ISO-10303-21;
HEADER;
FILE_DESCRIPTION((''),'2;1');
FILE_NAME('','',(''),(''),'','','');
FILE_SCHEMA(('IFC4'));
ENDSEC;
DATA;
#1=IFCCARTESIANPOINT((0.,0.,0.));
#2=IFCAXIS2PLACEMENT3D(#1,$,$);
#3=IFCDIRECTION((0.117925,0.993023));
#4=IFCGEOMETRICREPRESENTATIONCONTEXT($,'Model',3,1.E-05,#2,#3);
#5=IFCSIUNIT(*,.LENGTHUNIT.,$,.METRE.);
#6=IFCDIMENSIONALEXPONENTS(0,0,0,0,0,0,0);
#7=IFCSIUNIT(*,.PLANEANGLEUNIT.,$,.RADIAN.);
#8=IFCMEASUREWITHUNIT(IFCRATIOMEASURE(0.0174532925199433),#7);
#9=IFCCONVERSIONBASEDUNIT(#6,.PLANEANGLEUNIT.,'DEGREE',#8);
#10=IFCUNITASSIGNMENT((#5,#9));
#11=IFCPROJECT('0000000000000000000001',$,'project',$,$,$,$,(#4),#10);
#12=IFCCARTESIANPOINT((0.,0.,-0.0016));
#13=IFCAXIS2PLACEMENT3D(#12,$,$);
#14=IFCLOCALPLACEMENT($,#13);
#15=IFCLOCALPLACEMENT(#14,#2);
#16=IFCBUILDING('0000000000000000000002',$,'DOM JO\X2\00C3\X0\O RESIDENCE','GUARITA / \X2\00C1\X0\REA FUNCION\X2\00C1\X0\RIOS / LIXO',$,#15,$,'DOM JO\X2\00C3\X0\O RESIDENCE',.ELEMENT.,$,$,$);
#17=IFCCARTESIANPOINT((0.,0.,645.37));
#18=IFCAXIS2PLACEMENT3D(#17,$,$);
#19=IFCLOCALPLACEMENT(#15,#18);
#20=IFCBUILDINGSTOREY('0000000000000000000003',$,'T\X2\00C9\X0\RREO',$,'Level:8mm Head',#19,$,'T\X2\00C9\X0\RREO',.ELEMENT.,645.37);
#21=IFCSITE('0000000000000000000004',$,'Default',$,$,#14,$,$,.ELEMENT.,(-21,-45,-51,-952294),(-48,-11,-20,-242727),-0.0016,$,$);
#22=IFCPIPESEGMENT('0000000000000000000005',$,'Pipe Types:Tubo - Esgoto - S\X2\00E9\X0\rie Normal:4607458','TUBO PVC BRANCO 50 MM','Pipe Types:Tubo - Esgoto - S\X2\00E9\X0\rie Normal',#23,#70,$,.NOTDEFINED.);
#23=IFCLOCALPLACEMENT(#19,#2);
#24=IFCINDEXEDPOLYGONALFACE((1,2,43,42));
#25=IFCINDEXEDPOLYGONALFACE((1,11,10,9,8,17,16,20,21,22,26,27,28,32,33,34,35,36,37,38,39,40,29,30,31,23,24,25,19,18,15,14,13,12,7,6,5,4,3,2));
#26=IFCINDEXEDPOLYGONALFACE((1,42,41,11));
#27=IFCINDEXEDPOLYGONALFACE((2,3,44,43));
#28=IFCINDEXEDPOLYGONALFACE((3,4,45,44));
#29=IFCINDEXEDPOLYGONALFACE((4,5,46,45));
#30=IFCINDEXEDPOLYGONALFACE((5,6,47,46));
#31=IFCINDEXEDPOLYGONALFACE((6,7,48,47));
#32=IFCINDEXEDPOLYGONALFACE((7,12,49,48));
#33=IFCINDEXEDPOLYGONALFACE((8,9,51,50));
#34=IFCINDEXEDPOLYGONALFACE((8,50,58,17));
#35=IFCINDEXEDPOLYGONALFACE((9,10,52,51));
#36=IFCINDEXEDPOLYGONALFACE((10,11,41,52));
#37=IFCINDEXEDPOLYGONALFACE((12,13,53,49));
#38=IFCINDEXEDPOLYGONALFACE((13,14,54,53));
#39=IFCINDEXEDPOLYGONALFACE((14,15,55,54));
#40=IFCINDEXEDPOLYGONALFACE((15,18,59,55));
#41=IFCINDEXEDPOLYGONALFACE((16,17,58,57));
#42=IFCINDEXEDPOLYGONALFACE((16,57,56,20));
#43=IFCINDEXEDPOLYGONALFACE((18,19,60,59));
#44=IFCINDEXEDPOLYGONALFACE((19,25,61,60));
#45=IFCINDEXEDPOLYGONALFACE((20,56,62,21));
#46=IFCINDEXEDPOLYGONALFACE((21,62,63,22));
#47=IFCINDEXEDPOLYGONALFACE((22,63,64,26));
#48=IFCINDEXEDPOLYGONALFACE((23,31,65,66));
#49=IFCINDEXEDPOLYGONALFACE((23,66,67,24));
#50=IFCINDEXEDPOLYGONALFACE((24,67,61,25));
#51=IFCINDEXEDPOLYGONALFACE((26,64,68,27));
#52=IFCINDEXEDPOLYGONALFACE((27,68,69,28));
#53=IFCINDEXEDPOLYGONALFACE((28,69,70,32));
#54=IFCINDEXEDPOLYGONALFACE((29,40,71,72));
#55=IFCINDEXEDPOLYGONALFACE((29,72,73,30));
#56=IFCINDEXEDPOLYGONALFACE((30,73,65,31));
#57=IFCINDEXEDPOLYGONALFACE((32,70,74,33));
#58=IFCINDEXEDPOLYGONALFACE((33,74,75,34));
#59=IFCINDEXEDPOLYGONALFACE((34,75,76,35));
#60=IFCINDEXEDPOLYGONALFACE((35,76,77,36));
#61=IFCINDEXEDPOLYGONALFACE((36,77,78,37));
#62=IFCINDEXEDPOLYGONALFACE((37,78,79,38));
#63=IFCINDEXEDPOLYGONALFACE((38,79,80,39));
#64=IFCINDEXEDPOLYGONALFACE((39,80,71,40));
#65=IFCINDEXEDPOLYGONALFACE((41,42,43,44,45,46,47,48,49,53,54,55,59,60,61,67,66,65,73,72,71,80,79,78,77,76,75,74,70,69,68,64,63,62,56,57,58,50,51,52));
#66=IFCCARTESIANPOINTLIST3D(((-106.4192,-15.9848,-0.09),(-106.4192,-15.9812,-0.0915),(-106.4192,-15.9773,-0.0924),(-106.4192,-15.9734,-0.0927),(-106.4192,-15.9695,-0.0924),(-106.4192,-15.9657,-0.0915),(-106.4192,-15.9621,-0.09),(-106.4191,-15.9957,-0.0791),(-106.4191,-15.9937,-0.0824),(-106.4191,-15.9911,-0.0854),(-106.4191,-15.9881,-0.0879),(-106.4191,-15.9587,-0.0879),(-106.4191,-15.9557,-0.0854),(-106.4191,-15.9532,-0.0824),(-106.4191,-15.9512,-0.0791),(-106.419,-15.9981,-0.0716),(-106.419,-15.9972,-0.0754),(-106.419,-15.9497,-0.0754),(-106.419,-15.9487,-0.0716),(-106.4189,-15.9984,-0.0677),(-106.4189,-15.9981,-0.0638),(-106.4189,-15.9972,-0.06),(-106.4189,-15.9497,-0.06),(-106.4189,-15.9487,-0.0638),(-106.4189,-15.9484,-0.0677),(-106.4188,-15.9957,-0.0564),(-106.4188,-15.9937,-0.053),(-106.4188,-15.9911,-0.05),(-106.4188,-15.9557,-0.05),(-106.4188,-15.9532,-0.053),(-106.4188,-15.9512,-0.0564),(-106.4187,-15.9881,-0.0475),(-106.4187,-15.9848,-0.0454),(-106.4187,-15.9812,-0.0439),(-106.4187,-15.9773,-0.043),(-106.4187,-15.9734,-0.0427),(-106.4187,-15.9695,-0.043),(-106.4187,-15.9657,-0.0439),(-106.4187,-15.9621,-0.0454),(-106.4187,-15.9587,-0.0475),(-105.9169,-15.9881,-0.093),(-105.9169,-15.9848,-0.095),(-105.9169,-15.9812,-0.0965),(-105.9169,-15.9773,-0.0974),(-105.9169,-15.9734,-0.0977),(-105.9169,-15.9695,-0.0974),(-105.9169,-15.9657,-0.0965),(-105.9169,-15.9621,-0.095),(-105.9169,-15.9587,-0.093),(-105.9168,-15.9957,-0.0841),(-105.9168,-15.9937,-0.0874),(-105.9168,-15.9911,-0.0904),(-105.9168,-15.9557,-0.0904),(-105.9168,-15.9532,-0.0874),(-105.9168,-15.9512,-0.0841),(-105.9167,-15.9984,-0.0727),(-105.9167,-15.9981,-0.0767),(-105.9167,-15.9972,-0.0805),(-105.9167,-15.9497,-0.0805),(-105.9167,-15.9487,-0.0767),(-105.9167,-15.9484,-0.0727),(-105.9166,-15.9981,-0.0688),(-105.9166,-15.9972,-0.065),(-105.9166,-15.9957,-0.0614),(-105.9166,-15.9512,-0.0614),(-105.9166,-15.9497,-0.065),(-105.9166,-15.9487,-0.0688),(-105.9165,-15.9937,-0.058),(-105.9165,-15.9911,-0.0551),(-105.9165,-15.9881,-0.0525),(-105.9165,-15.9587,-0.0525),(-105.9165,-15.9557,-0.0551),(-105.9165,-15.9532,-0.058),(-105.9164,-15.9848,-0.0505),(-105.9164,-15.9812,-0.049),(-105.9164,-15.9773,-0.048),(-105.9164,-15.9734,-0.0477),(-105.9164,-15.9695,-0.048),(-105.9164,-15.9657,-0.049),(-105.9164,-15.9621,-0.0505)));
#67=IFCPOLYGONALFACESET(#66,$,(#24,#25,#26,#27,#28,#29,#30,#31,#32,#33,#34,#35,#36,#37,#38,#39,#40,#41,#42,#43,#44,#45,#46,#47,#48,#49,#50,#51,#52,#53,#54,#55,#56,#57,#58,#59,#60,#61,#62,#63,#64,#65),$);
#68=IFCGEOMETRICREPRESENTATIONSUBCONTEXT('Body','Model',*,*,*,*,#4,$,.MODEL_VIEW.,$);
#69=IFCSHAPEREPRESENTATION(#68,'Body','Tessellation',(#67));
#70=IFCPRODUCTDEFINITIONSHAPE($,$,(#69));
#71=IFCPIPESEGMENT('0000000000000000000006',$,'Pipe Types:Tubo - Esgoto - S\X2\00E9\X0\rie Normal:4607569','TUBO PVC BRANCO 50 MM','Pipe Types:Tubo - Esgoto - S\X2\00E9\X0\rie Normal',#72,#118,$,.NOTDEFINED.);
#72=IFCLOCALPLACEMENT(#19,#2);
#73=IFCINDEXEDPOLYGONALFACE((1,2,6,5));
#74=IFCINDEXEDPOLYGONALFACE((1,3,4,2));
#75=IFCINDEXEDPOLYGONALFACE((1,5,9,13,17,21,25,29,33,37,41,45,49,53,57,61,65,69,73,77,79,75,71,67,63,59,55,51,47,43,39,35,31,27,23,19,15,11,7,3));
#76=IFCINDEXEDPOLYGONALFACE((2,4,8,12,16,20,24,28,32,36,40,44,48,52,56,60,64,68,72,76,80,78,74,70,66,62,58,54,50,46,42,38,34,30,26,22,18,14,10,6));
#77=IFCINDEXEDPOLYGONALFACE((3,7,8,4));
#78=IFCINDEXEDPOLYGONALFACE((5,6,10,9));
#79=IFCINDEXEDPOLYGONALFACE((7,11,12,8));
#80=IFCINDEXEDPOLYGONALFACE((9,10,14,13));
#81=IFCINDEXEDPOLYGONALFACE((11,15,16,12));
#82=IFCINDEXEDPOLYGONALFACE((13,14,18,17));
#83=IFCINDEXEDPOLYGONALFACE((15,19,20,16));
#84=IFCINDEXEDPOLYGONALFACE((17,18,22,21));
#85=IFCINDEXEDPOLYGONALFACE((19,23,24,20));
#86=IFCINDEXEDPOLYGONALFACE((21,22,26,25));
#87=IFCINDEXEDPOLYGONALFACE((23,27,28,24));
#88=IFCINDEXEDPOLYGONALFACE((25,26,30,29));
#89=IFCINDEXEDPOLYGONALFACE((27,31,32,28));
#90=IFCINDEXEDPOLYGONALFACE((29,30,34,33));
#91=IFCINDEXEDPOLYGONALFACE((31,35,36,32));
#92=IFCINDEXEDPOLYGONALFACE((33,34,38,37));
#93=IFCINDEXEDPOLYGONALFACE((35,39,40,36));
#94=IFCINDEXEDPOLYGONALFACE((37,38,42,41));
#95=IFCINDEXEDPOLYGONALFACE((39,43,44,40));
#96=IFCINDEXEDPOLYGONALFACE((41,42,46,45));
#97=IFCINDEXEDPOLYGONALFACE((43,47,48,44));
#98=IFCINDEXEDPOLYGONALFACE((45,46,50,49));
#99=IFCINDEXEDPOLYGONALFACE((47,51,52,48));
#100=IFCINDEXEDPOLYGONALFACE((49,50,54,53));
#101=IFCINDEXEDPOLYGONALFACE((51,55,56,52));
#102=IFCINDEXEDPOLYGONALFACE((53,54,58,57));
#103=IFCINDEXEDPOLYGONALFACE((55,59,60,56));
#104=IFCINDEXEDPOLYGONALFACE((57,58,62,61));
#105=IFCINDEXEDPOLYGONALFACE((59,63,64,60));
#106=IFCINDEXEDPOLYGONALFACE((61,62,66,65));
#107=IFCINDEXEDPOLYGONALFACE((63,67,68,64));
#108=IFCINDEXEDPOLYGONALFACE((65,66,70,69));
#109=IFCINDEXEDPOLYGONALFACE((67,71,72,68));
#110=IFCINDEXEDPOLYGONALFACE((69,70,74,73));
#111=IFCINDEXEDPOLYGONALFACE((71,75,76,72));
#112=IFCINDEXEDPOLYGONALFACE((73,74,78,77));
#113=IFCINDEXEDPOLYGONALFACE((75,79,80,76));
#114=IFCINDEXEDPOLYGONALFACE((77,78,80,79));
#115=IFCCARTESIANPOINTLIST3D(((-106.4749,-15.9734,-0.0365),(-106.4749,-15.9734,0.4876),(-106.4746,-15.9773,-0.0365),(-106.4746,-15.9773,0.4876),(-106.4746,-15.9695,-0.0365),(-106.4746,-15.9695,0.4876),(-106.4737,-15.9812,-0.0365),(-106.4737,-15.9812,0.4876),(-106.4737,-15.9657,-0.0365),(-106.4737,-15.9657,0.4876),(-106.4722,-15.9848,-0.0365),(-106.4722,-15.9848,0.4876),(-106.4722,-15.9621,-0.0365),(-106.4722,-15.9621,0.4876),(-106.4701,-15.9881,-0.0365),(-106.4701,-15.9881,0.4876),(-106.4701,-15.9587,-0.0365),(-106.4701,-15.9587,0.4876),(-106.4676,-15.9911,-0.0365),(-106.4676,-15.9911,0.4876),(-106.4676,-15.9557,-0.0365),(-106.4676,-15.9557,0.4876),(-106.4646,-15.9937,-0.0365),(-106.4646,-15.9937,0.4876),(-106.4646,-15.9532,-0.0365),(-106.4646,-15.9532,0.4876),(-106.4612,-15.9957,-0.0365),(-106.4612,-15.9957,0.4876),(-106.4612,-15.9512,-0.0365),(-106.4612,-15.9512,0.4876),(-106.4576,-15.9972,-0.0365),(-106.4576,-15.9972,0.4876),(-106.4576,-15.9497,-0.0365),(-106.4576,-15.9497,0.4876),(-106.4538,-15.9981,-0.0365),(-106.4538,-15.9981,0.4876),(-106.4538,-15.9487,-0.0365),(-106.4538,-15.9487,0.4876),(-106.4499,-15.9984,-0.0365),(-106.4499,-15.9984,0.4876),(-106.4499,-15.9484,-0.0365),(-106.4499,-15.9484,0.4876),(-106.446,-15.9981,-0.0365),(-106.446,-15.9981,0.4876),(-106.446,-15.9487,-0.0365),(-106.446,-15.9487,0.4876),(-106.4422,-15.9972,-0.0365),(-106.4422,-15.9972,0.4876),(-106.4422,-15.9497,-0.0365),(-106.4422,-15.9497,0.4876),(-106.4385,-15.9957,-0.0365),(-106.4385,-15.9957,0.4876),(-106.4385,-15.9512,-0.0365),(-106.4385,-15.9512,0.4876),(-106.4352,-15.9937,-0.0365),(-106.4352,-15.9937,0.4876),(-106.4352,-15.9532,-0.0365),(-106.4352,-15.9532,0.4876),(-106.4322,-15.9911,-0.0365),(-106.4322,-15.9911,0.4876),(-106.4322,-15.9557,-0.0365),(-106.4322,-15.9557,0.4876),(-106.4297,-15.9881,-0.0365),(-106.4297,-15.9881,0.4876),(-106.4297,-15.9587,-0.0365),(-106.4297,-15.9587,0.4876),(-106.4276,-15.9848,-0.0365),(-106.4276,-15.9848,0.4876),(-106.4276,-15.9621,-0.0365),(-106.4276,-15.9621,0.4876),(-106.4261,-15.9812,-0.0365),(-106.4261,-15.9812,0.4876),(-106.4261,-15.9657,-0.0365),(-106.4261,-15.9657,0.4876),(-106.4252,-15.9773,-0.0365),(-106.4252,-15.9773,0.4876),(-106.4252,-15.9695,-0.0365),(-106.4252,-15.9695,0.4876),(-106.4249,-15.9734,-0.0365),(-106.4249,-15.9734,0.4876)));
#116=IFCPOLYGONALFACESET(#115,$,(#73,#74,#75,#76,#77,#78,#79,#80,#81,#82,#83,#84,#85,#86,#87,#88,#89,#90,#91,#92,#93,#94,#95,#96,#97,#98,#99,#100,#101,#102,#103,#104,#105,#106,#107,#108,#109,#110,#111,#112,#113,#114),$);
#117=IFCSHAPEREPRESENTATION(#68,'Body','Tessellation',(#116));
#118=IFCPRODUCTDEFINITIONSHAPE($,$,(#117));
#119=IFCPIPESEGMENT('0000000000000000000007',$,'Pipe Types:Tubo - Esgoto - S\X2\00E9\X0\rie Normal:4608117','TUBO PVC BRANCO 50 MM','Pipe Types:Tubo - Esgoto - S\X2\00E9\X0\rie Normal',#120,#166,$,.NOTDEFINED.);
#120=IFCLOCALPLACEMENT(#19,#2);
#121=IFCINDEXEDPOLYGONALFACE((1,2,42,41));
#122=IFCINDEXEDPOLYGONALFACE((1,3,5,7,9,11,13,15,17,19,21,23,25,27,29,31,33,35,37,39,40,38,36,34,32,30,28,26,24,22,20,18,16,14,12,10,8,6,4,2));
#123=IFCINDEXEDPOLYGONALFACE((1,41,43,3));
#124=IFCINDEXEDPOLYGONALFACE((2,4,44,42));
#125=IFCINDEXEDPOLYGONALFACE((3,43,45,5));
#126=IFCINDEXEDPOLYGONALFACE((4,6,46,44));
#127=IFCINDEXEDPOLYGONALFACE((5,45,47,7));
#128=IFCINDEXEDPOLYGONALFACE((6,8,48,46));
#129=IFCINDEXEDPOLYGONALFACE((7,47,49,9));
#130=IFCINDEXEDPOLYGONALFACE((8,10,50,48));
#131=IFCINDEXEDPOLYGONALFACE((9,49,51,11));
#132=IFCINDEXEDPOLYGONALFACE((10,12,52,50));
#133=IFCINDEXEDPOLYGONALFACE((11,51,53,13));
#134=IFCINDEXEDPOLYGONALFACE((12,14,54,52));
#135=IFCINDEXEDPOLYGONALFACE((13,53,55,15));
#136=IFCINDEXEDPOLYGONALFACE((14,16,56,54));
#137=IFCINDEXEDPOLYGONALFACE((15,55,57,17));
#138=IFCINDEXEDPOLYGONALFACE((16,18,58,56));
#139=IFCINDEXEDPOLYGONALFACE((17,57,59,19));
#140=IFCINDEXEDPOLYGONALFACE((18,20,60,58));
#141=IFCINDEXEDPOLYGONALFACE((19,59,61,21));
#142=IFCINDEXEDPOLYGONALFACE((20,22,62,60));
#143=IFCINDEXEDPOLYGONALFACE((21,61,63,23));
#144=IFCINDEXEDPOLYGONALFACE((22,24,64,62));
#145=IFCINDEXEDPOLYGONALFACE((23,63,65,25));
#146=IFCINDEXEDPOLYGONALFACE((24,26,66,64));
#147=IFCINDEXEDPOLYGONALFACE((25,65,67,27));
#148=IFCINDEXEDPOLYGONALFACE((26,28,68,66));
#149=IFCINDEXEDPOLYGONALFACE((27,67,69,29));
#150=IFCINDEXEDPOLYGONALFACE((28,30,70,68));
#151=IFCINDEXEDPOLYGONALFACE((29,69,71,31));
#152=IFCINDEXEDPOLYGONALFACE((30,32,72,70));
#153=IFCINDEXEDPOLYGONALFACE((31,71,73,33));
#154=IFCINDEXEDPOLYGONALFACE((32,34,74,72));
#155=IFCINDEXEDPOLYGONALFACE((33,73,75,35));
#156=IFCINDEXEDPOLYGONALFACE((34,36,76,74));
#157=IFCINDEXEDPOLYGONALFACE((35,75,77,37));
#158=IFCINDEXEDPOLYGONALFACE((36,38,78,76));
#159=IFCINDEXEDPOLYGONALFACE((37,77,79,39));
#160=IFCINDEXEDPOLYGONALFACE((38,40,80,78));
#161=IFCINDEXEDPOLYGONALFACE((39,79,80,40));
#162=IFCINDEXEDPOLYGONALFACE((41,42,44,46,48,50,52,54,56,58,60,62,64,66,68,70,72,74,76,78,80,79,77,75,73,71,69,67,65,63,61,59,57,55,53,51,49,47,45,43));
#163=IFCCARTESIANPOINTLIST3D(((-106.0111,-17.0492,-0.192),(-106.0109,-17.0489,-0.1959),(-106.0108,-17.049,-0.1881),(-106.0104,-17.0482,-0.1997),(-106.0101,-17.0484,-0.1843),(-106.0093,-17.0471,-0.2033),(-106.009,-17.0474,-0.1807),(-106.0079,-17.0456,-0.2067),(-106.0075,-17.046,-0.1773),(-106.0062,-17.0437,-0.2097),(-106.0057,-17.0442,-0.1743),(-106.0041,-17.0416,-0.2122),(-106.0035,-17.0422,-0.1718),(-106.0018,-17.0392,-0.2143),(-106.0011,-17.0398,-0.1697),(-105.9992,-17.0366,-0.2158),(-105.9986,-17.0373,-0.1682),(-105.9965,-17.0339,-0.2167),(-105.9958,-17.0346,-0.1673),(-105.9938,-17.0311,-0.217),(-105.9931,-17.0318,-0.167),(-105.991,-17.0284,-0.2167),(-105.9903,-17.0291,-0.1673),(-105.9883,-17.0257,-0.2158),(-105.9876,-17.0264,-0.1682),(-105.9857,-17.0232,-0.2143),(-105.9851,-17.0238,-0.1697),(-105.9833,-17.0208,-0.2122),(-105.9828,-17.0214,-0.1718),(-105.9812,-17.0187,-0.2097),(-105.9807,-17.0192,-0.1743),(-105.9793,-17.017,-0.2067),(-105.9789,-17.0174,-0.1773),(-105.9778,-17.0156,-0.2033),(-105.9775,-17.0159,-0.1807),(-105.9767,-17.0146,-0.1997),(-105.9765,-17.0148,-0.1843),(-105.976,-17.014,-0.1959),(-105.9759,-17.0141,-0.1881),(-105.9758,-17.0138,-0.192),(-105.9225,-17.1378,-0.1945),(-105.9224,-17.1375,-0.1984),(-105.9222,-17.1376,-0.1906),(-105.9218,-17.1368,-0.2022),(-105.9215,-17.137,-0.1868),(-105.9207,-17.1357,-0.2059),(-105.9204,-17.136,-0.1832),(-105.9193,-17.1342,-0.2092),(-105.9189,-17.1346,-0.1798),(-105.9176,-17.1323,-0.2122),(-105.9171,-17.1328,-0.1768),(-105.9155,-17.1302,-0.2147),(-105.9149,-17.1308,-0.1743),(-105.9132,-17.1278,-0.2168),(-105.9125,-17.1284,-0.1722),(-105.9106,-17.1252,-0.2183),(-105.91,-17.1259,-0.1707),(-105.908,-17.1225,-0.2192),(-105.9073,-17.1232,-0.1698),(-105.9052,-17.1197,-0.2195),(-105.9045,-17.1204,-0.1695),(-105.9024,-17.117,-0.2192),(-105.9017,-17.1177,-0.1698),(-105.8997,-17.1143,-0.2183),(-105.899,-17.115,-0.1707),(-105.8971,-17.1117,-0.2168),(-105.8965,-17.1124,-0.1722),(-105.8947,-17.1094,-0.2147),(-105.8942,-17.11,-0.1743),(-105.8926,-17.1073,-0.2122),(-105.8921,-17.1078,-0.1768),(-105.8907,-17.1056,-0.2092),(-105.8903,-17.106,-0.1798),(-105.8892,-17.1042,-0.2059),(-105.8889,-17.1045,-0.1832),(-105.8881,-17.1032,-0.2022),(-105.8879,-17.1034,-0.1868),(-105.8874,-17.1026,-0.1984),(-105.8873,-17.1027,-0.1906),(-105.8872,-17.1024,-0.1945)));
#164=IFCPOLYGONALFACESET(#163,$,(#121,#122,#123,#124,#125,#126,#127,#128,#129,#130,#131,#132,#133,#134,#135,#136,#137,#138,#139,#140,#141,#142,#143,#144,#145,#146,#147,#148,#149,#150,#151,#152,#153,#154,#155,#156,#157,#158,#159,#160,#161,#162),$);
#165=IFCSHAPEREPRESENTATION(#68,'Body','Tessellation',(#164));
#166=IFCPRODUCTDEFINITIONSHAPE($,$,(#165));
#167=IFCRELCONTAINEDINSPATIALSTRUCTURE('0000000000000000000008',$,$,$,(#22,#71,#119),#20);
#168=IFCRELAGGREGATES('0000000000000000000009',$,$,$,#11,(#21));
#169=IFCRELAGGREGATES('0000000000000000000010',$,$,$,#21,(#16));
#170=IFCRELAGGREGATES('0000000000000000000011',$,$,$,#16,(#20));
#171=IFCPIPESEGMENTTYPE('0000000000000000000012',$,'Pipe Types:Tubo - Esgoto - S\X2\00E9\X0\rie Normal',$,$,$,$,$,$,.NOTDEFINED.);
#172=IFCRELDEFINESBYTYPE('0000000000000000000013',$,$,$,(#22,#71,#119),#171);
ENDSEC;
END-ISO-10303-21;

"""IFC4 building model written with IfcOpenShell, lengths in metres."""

from ifc_helpers import new_model, entity, si_unit, converted_unit, direction, frame, origin, place, context, subcontext, project, spatial, indexed_curve, outline, extrude, type_object, element, save


model = new_model("IFC4")

# Units and contexts
model_context = context("Model", 3, precision=1e-05, world=origin(), true_north=direction((0.117925, 0.993023)))
body_context = subcontext(model_context, "Body", "Model", "MODEL_VIEW")
ifc_project = project(units=[si_unit("LENGTHUNIT", "METRE"), converted_unit("PLANEANGLEUNIT", "DEGREE", entity("IfcRatioMeasure", 0.0174532925199433), si_unit("PLANEANGLEUNIT", "RADIAN"), dimensions=[0, 0, 0, 0, 0, 0, 0])], contexts=[model_context])

# Site, building, storey
site_placement = place(None, frame((0.0, 0.0, -0.0016)))
site = spatial("IfcSite", under=ifc_project, at=site_placement, Name="Default", CompositionType="ELEMENT", RefLatitude=(-21, -45, -51, -952294), RefLongitude=(-48, -11, -20, -242727), RefElevation=-0.0016)
building_placement = place(site_placement, origin())
building = spatial("IfcBuilding", under=site, at=building_placement, Name="DOM JOÃO RESIDENCE", Description="GUARITA / ÁREA FUNCIONÁRIOS / LIXO", LongName="DOM JOÃO RESIDENCE", CompositionType="ELEMENT")
storey_placement = place(building_placement, frame((0.0, 0.0, 645.37)))
storey = spatial("IfcBuildingStorey", under=building, at=storey_placement, Name="TÉRREO", ObjectType="Level:8mm Head", LongName="TÉRREO", CompositionType="ELEMENT", Elevation=645.37)

# Pipe segments
pipe_segment_type_1 = type_object("IfcPipeSegmentType", Name="Pipe Types:Tubo - Esgoto - Série Normal", PredefinedType="NOTDEFINED")
pipe_segment_1_placement = place(storey_placement, frame((-106.4208, -16.0, -0.0993)))
element("IfcPipeSegment", 1, at=pipe_segment_1_placement, inside=storey, type_object=pipe_segment_type_1, Name="Pipe Types:Tubo - Esgoto - Série Normal:4607458", Description="TUBO PVC BRANCO 50 MM", ObjectType="Pipe Types:Tubo - Esgoto - Série Normal", PredefinedType="NOTDEFINED", context=body_context, shape_type="SweptSolid", body=[
    extrude(outline(indexed_curve([(0.025, 0.0), (0.0247, 0.0039), (0.0238, 0.0077), (0.0223, 0.0113), (0.0202, 0.0147), (0.0177, 0.0177), (0.0147, 0.0202), (0.0113, 0.0223), (0.0077, 0.0238), (0.0039, 0.0247), (0.0, 0.025), (-0.0039, 0.0247), (-0.0077, 0.0238), (-0.0113, 0.0223), (-0.0147, 0.0202), (-0.0177, 0.0177), (-0.0202, 0.0147), (-0.0223, 0.0113), (-0.0238, 0.0077), (-0.0247, 0.0039), (-0.025, 0.0), (-0.0247, -0.0039), (-0.0238, -0.0077), (-0.0223, -0.0113), (-0.0202, -0.0147), (-0.0177, -0.0177), (-0.0147, -0.0202), (-0.0113, -0.0223), (-0.0077, -0.0238), (-0.0039, -0.0247), (0.0, -0.025), (0.0039, -0.0247), (0.0077, -0.0238), (0.0113, -0.0223), (0.0147, -0.0202), (0.0177, -0.0177), (0.0202, -0.0147), (0.0223, -0.0113), (0.0238, -0.0077), (0.0247, -0.0039), (0.025, 0.0)], self_intersect=False)), frame((0.0018, 0.0266, 0.0316), z_axis=(0.99995, 0.0, -0.01), x_axis=(0.0, 1.0, 0.0)), (0.0, 0.0, 1.0), 0.5023),
])
pipe_segment_2_placement = place(storey_placement, frame((-106.4765, -16.0, -0.0365)))
element("IfcPipeSegment", 2, at=pipe_segment_2_placement, inside=storey, type_object=pipe_segment_type_1, Name="Pipe Types:Tubo - Esgoto - Série Normal:4607569", Description="TUBO PVC BRANCO 50 MM", ObjectType="Pipe Types:Tubo - Esgoto - Série Normal", PredefinedType="NOTDEFINED", context=body_context, shape_type="SweptSolid", body=[
    extrude(outline(indexed_curve([(0.025, 0.0), (0.0247, 0.0039), (0.0238, 0.0077), (0.0223, 0.0113), (0.0202, 0.0147), (0.0177, 0.0177), (0.0147, 0.0202), (0.0113, 0.0223), (0.0077, 0.0238), (0.0039, 0.0247), (0.0, 0.025), (-0.0039, 0.0247), (-0.0077, 0.0238), (-0.0113, 0.0223), (-0.0147, 0.0202), (-0.0177, 0.0177), (-0.0202, 0.0147), (-0.0223, 0.0113), (-0.0238, 0.0077), (-0.0247, 0.0039), (-0.025, 0.0), (-0.0247, -0.0039), (-0.0238, -0.0077), (-0.0223, -0.0113), (-0.0202, -0.0147), (-0.0177, -0.0177), (-0.0147, -0.0202), (-0.0113, -0.0223), (-0.0077, -0.0238), (-0.0039, -0.0247), (0.0, -0.025), (0.0039, -0.0247), (0.0077, -0.0238), (0.0113, -0.0223), (0.0147, -0.0202), (0.0177, -0.0177), (0.0202, -0.0147), (0.0223, -0.0113), (0.0238, -0.0077), (0.0247, -0.0039), (0.025, 0.0)], self_intersect=False)), frame((0.0266, 0.0266, 0.0), z_axis=(0.0, 0.0, 1.0), x_axis=(-1.0, 0.0, 0.0)), (0.0, 0.0, 1.0), 0.524),
])
pipe_segment_3_placement = place(storey_placement, frame((-106.0127, -17.1394, -0.2211)))
element("IfcPipeSegment", 3, at=pipe_segment_3_placement, inside=storey, type_object=pipe_segment_type_1, Name="Pipe Types:Tubo - Esgoto - Série Normal:4608117", Description="TUBO PVC BRANCO 50 MM", ObjectType="Pipe Types:Tubo - Esgoto - Série Normal", PredefinedType="NOTDEFINED", context=body_context, shape_type="SweptSolid", body=[
    extrude(outline(indexed_curve([(0.025, 0.0), (0.0247, 0.0039), (0.0238, 0.0077), (0.0223, 0.0113), (0.0202, 0.0147), (0.0177, 0.0177), (0.0147, 0.0202), (0.0113, 0.0223), (0.0077, 0.0238), (0.0039, 0.0247), (0.0, 0.025), (-0.0039, 0.0247), (-0.0077, 0.0238), (-0.0113, 0.0223), (-0.0147, 0.0202), (-0.0177, 0.0177), (-0.0202, 0.0147), (-0.0223, 0.0113), (-0.0238, 0.0077), (-0.0247, 0.0039), (-0.025, 0.0), (-0.0247, -0.0039), (-0.0238, -0.0077), (-0.0223, -0.0113), (-0.0202, -0.0147), (-0.0177, -0.0177), (-0.0147, -0.0202), (-0.0113, -0.0223), (-0.0077, -0.0238), (-0.0039, -0.0247), (0.0, -0.025), (0.0039, -0.0247), (0.0077, -0.0238), (0.0113, -0.0223), (0.0147, -0.0202), (0.0177, -0.0177), (0.0202, -0.0147), (0.0223, -0.0113), (0.0238, -0.0077), (0.0247, -0.0039), (0.025, 0.0)], self_intersect=False)), frame((0.0193, 0.1079, 0.0291), z_axis=(0.706965, -0.706965, -0.019996), x_axis=(0.707107, 0.707107, 0.0)), (0.0, 0.0, 1.0), 0.1253),
])

save(model, "model.ifc")
